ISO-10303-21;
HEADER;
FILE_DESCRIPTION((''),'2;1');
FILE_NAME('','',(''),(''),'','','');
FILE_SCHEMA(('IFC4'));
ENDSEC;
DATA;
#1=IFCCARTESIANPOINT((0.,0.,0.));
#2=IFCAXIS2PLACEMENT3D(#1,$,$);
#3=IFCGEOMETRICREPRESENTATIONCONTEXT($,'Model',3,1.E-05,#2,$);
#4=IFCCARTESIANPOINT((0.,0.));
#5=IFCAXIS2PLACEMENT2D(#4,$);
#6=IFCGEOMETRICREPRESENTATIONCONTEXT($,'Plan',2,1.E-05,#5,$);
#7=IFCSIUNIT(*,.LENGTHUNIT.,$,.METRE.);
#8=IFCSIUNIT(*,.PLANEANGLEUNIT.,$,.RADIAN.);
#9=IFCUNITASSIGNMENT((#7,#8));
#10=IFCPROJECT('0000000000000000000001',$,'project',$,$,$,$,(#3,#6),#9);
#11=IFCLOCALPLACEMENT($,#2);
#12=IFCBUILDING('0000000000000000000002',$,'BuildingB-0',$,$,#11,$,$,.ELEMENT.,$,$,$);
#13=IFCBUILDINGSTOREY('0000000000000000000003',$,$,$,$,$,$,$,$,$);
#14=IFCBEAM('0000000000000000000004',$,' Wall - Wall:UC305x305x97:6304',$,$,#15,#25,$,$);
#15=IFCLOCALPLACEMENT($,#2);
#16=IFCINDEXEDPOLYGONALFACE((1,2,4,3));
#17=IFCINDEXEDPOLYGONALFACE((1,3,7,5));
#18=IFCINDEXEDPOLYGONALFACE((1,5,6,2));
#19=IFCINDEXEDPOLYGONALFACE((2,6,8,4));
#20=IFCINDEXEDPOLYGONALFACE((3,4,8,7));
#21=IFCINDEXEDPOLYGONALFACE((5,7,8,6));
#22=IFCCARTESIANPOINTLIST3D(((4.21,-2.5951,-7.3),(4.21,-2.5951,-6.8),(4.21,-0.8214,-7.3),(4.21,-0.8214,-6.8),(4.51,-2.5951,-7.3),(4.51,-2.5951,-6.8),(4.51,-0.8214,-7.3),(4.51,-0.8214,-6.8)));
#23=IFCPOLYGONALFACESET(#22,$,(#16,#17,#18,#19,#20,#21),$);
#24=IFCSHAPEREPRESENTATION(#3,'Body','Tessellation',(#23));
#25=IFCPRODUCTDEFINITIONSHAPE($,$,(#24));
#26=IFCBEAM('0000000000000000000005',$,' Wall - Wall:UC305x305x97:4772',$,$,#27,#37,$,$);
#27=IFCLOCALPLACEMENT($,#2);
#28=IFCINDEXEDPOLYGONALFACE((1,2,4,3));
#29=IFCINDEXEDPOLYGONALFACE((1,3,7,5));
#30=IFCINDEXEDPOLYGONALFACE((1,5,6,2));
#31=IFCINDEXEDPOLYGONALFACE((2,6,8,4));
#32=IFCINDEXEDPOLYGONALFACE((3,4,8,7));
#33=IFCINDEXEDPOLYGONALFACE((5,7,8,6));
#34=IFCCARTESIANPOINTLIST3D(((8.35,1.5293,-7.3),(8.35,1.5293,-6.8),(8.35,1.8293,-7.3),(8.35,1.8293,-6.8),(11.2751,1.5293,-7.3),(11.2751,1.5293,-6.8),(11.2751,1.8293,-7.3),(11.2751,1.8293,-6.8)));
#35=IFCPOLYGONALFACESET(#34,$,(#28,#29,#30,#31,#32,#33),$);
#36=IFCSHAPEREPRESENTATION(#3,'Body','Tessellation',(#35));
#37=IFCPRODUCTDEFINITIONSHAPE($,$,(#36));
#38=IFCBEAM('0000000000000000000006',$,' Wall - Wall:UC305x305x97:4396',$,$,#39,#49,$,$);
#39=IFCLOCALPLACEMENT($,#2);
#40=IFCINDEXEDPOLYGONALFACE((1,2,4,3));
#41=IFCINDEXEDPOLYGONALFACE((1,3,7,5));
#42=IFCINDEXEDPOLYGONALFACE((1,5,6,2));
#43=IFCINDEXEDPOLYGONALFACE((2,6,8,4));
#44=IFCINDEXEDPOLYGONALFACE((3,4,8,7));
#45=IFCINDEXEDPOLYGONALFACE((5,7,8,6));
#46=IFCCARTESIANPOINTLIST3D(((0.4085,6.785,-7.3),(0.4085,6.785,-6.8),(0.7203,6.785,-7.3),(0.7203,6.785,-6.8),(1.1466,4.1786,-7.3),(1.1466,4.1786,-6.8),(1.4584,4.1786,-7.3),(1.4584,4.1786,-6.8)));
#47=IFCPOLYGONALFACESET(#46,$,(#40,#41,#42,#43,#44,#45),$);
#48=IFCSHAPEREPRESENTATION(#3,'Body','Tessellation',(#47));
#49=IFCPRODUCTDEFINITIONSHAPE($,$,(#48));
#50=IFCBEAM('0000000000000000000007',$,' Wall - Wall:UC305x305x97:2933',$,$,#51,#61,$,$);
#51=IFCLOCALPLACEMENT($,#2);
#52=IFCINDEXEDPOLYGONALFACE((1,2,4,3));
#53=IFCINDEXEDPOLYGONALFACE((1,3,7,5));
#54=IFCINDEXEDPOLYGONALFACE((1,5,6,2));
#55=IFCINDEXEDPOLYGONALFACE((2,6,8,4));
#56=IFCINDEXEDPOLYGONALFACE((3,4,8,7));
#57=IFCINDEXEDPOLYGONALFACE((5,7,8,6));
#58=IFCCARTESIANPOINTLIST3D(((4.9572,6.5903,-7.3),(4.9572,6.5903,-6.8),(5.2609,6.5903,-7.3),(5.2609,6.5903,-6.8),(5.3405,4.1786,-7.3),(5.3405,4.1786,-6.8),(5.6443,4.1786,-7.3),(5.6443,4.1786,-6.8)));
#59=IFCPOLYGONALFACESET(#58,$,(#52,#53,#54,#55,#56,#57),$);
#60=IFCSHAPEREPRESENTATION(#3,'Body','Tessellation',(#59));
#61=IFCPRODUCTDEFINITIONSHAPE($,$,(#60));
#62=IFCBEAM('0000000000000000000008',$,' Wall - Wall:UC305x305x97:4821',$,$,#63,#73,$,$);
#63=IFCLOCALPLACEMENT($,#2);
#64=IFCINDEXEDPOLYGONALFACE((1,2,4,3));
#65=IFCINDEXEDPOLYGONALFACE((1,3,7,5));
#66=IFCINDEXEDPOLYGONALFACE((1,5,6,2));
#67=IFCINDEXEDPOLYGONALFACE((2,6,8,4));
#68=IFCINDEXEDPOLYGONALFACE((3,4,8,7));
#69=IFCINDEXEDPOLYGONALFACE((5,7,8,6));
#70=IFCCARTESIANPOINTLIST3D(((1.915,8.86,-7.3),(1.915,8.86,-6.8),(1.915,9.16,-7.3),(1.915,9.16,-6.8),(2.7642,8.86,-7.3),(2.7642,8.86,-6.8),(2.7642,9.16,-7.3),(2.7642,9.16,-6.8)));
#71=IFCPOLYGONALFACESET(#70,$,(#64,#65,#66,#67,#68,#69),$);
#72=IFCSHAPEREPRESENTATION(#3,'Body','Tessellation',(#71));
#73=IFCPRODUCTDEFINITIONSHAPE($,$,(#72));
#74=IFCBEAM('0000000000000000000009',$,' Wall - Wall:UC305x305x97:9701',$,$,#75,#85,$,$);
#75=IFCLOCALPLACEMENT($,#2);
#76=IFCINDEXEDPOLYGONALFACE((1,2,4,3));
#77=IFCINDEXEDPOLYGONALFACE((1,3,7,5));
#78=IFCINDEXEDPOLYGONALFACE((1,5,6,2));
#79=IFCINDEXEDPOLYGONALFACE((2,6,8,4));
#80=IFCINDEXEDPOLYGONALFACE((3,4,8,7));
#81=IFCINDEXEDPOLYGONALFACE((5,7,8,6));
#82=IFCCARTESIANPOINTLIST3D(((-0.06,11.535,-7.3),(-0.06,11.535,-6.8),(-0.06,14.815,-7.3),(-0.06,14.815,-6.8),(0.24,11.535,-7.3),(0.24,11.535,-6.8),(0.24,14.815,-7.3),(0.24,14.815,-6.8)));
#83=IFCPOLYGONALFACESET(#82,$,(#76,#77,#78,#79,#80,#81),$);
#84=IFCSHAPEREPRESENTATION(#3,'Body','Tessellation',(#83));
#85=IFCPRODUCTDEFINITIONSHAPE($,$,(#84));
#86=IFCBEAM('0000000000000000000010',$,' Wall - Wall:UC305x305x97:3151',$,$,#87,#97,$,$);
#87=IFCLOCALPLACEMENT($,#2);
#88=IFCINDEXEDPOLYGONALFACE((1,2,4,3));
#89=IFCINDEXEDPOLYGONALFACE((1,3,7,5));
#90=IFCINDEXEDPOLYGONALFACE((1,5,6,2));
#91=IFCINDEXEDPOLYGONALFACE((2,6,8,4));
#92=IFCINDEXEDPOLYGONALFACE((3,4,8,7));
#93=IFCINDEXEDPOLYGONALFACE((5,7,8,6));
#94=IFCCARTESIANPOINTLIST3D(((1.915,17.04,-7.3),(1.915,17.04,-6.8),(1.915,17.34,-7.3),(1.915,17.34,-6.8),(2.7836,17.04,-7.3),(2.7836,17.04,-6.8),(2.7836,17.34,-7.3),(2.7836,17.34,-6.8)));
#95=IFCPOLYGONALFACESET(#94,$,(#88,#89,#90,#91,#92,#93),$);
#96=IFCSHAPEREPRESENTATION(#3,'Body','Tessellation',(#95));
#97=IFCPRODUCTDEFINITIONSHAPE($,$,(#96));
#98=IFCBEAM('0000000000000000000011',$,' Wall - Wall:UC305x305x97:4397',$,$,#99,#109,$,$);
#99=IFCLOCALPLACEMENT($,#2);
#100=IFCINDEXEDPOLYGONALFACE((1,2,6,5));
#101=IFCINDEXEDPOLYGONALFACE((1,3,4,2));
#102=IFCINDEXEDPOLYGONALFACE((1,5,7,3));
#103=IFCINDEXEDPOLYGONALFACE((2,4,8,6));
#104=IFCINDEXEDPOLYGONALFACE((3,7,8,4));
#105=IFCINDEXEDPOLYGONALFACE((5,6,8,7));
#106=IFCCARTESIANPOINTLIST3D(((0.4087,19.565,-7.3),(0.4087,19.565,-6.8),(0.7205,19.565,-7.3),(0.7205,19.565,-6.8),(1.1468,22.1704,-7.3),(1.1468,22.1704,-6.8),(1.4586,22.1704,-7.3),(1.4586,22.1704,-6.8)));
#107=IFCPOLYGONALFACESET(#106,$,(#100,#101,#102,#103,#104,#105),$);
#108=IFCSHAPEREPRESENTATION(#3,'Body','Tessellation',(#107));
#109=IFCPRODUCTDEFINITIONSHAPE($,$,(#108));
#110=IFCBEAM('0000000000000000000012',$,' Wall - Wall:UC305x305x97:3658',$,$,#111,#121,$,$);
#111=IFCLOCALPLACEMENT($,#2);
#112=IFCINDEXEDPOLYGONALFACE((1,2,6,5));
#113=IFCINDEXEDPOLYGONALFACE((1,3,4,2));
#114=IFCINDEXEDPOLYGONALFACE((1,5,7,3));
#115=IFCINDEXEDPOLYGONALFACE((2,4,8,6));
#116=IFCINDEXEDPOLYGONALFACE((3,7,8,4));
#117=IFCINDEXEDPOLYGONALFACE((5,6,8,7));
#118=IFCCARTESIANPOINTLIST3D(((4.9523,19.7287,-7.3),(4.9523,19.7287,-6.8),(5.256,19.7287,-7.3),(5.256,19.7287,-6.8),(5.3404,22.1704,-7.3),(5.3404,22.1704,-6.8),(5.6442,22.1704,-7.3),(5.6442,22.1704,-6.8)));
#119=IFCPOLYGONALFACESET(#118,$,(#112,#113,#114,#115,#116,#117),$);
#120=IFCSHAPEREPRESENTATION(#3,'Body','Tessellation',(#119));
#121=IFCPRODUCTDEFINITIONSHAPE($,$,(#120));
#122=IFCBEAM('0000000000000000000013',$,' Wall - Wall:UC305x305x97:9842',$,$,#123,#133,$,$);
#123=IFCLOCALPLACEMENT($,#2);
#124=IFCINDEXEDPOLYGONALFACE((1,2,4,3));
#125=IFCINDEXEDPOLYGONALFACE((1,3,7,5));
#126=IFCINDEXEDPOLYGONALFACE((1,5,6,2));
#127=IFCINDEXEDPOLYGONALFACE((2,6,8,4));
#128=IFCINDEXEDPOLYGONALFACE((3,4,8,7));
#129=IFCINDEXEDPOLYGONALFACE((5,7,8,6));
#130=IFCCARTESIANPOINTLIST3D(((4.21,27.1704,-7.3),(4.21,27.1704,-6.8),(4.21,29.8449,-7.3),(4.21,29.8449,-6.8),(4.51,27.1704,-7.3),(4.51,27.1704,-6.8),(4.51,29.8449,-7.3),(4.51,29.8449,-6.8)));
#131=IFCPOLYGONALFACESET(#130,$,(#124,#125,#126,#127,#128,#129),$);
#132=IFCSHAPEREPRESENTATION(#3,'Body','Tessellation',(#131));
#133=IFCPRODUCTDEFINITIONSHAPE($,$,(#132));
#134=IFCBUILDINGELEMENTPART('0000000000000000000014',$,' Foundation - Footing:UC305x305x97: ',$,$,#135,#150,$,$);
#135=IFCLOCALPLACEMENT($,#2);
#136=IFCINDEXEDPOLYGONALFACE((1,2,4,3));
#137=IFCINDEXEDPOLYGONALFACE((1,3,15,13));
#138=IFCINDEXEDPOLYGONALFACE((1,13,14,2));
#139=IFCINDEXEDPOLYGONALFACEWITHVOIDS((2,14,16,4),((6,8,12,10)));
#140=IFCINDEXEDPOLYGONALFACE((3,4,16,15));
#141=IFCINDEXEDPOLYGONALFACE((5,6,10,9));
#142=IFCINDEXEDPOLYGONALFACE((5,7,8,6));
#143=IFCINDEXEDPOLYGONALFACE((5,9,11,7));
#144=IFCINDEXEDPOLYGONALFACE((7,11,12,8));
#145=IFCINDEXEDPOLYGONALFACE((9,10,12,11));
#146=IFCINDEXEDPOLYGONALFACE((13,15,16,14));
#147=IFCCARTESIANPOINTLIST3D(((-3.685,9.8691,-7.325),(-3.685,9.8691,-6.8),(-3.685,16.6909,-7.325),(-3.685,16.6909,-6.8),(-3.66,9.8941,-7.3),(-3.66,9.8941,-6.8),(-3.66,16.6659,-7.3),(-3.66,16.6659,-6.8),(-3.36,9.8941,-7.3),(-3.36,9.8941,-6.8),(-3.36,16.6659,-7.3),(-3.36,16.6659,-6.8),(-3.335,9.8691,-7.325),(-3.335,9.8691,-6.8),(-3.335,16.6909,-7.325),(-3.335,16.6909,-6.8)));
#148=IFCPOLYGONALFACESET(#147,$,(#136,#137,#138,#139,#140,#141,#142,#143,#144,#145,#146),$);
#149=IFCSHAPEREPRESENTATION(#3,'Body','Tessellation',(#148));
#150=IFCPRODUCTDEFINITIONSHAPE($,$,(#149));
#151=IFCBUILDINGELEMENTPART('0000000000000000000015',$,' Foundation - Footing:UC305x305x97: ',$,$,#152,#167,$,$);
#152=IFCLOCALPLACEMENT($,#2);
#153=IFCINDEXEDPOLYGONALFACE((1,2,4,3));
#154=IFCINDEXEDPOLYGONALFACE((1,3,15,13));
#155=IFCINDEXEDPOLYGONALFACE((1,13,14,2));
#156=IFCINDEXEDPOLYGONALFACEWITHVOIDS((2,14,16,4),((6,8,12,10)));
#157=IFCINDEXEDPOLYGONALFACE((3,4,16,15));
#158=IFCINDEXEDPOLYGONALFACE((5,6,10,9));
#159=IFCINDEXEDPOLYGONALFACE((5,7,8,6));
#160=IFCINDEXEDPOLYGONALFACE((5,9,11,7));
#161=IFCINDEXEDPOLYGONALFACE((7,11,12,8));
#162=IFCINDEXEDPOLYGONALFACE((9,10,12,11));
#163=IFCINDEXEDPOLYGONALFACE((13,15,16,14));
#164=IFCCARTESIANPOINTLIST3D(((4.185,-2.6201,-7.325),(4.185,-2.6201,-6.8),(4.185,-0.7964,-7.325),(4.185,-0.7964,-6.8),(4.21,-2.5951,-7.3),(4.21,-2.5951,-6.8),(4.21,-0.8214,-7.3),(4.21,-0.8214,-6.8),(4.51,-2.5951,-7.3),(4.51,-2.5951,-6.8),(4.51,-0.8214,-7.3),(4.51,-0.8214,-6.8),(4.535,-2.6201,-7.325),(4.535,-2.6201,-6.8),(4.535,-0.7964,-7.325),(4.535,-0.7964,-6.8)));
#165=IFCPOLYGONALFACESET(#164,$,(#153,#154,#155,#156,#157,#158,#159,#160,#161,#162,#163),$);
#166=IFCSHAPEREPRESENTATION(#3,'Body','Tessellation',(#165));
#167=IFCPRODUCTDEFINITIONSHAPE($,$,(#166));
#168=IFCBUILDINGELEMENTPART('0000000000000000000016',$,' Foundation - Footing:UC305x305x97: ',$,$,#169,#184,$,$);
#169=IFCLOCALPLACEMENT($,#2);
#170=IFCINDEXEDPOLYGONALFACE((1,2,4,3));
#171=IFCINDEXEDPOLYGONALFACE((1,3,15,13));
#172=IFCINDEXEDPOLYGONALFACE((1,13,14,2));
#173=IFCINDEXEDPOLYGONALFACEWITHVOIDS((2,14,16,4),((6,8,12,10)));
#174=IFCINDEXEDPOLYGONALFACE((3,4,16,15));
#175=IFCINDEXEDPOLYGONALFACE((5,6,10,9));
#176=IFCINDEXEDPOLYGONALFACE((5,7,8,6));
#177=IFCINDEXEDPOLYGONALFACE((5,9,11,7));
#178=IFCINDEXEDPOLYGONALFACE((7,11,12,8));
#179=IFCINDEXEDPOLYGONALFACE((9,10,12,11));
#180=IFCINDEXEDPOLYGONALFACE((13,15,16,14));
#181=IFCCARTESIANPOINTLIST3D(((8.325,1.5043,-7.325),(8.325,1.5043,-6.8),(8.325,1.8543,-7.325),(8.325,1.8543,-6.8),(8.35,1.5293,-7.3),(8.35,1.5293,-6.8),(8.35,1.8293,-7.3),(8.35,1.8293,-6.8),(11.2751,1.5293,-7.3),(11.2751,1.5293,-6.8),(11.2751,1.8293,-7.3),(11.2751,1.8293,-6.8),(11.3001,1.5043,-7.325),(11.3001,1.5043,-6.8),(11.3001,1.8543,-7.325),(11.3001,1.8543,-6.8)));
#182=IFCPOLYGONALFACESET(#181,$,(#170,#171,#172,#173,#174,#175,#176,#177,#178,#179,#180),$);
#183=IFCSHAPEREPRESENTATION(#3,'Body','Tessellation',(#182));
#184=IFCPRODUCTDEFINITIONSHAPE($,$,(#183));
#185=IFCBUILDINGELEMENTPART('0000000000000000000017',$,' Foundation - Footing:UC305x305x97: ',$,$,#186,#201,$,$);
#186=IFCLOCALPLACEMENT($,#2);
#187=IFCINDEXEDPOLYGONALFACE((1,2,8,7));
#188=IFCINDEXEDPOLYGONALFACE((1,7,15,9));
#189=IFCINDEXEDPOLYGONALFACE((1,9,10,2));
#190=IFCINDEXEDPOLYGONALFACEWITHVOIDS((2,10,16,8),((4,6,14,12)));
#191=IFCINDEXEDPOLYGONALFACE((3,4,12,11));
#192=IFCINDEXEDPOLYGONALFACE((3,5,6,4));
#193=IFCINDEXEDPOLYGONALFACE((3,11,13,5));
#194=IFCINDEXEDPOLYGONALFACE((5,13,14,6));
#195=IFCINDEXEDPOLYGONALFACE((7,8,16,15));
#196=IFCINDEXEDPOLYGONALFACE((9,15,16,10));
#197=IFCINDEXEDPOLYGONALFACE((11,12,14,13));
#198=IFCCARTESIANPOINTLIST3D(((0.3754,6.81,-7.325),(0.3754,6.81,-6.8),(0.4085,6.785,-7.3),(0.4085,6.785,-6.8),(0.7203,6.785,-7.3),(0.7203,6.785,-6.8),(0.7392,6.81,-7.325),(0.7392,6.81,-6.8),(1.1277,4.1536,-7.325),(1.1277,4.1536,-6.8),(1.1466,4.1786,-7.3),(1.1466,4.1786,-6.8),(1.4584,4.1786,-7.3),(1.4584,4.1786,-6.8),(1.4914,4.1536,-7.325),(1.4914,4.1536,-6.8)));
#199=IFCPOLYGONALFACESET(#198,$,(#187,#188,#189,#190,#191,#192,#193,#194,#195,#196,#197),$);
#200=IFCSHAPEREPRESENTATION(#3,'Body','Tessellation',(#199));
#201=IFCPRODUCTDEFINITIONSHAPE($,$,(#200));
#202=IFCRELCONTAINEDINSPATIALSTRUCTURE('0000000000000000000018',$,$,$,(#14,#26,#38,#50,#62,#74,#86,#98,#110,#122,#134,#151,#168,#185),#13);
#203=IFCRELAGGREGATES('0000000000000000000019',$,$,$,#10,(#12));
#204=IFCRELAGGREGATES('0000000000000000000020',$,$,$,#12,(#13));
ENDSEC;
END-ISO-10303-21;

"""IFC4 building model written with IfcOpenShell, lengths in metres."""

from ifc_helpers import new_model, si_unit, origin, origin_2d, place, context, project, spatial, polyline, outline, extrude, element, save


model = new_model("IFC4")

# Units and contexts
model_context = context("Model", 3, precision=1e-05, world=origin())
plan_context = context("Plan", 2, precision=1e-05, world=origin_2d())
ifc_project = project(units=[si_unit("LENGTHUNIT", "METRE"), si_unit("PLANEANGLEUNIT", "RADIAN")], contexts=[model_context, plan_context])

# Building, storey
building_placement = place(None, origin())
building = spatial("IfcBuilding", under=ifc_project, at=building_placement, Name="BuildingB-0", CompositionType="ELEMENT")
storey = spatial("IfcBuildingStorey", under=building)

# Beams
element("IfcBeam", 1, inside=storey, Name=" Wall - Wall:UC305x305x97:6304", context=model_context, shape_type="SweptSolid", body=[
    extrude(outline(polyline([(4.21, -2.5951, -7.3), (4.51, -2.5951, -7.3), (4.51, -0.8214, -7.3), (4.21, -0.8214, -7.3), (4.21, -2.5951, -7.3)])), None, (0.0, 0.0, 1.0), 0.5),
])
element("IfcBeam", 2, inside=storey, Name=" Wall - Wall:UC305x305x97:4772", context=model_context, shape_type="SweptSolid", body=[
    extrude(outline(polyline([(8.35, 1.5293, -7.3), (8.35, 1.8293, -7.3), (11.2751, 1.8293, -7.3), (11.2751, 1.5293, -7.3), (8.35, 1.5293, -7.3)])), None, (0.0, 0.0, 1.0), 0.5),
])
element("IfcBeam", 3, inside=storey, Name=" Wall - Wall:UC305x305x97:4396", context=model_context, shape_type="SweptSolid", body=[
    extrude(outline(polyline([(1.1466, 4.1786, -7.3), (0.4085, 6.785, -7.3), (0.7203, 6.785, -7.3), (1.4584, 4.1786, -7.3), (1.1466, 4.1786, -7.3)])), None, (0.0, 0.0, 1.0), 0.5),
])
element("IfcBeam", 4, inside=storey, Name=" Wall - Wall:UC305x305x97:2933", context=model_context, shape_type="SweptSolid", body=[
    extrude(outline(polyline([(5.3405, 4.1786, -7.3), (4.9572, 6.5903, -7.3), (5.2609, 6.5903, -7.3), (5.6443, 4.1786, -7.3), (5.3405, 4.1786, -7.3)])), None, (0.0, 0.0, 1.0), 0.5),
])
element("IfcBeam", 5, inside=storey, Name=" Wall - Wall:UC305x305x97:4821", context=model_context, shape_type="SweptSolid", body=[
    extrude(outline(polyline([(1.915, 8.86, -7.3), (1.915, 9.16, -7.3), (2.7642, 9.16, -7.3), (2.7642, 8.86, -7.3), (1.915, 8.86, -7.3)])), None, (0.0, 0.0, 1.0), 0.5),
])
element("IfcBeam", 6, inside=storey, Name=" Wall - Wall:UC305x305x97:9701", context=model_context, shape_type="SweptSolid", body=[
    extrude(outline(polyline([(-0.06, 11.535, -7.3), (-0.06, 14.815, -7.3), (0.24, 14.815, -7.3), (0.24, 11.535, -7.3), (-0.06, 11.535, -7.3)])), None, (0.0, 0.0, 1.0), 0.5),
])
element("IfcBeam", 7, inside=storey, Name=" Wall - Wall:UC305x305x97:3151", context=model_context, shape_type="SweptSolid", body=[
    extrude(outline(polyline([(1.915, 17.04, -7.3), (1.915, 17.34, -7.3), (2.7836, 17.34, -7.3), (2.7836, 17.04, -7.3), (1.915, 17.04, -7.3)])), None, (0.0, 0.0, 1.0), 0.5),
])
element("IfcBeam", 8, inside=storey, Name=" Wall - Wall:UC305x305x97:4397", context=model_context, shape_type="SweptSolid", body=[
    extrude(outline(polyline([(0.4087, 19.565, -7.3), (1.1468, 22.1704, -7.3), (1.4586, 22.1704, -7.3), (0.7205, 19.565, -7.3), (0.4087, 19.565, -7.3)])), None, (0.0, 0.0, 1.0), 0.5),
])
element("IfcBeam", 9, inside=storey, Name=" Wall - Wall:UC305x305x97:3658", context=model_context, shape_type="SweptSolid", body=[
    extrude(outline(polyline([(5.256, 19.7287, -7.3), (4.9523, 19.7287, -7.3), (5.3404, 22.1704, -7.3), (5.6442, 22.1704, -7.3), (5.256, 19.7287, -7.3)])), None, (0.0, 0.0, 1.0), 0.5),
])
element("IfcBeam", 10, inside=storey, Name=" Wall - Wall:UC305x305x97:9842", context=model_context, shape_type="SweptSolid", body=[
    extrude(outline(polyline([(4.51, 27.1704, -7.3), (4.21, 27.1704, -7.3), (4.21, 29.8449, -7.3), (4.51, 29.8449, -7.3), (4.51, 27.1704, -7.3)])), None, (0.0, 0.0, 1.0), 0.5),
])

# Building element parts, openings
building_element_part_1 = element("IfcBuildingElementPart", 11, inside=storey, Name=" Foundation - Footing:UC305x305x97: ", context=model_context, shape_type="SweptSolid", body=[
    extrude(outline(polyline([(-3.685, 9.8691, -7.325), (-3.335, 9.8691, -7.325), (-3.335, 16.6909, -7.325), (-3.685, 16.6909, -7.325), (-3.685, 9.8691, -7.325)])), None, (0.0, 0.0, 1.0), 0.525),
])
element("IfcOpeningElement", 12, inside=storey, cuts=building_element_part_1, context=model_context, shape_type="SweptSolid", body=[
    extrude(outline(polyline([(-3.66, 9.8941, -7.3), (-3.36, 9.8941, -7.3), (-3.36, 16.6659, -7.3), (-3.66, 16.6659, -7.3), (-3.66, 9.8941, -7.3)])), None, (0.0, 0.0, 1.0), 0.5),
])
building_element_part_2 = element("IfcBuildingElementPart", 13, inside=storey, Name=" Foundation - Footing:UC305x305x97: ", context=model_context, shape_type="SweptSolid", body=[
    extrude(outline(polyline([(4.185, -2.6201, -7.325), (4.535, -2.6201, -7.325), (4.535, -0.7964, -7.325), (4.185, -0.7964, -7.325), (4.185, -2.6201, -7.325)])), None, (0.0, 0.0, 1.0), 0.525),
])
element("IfcOpeningElement", 14, inside=storey, cuts=building_element_part_2, context=model_context, shape_type="SweptSolid", body=[
    extrude(outline(polyline([(4.21, -2.5951, -7.3), (4.51, -2.5951, -7.3), (4.51, -0.8214, -7.3), (4.21, -0.8214, -7.3), (4.21, -2.5951, -7.3)])), None, (0.0, 0.0, 1.0), 0.5),
])
building_element_part_3 = element("IfcBuildingElementPart", 15, inside=storey, Name=" Foundation - Footing:UC305x305x97: ", context=model_context, shape_type="SweptSolid", body=[
    extrude(outline(polyline([(8.325, 1.5043, -7.325), (8.325, 1.8543, -7.325), (11.3001, 1.8543, -7.325), (11.3001, 1.5043, -7.325), (8.325, 1.5043, -7.325)])), None, (0.0, 0.0, 1.0), 0.525),
])
element("IfcOpeningElement", 16, inside=storey, cuts=building_element_part_3, context=model_context, shape_type="SweptSolid", body=[
    extrude(outline(polyline([(8.35, 1.5293, -7.3), (8.35, 1.8293, -7.3), (11.2751, 1.8293, -7.3), (11.2751, 1.5293, -7.3), (8.35, 1.5293, -7.3)])), None, (0.0, 0.0, 1.0), 0.5),
])
building_element_part_4 = element("IfcBuildingElementPart", 17, inside=storey, Name=" Foundation - Footing:UC305x305x97: ", context=model_context, shape_type="SweptSolid", body=[
    extrude(outline(polyline([(1.1277, 4.1536, -7.325), (0.3754, 6.81, -7.325), (0.7392, 6.81, -7.325), (1.4914, 4.1536, -7.325), (1.1277, 4.1536, -7.325)])), None, (0.0, 0.0, 1.0), 0.525),
])
element("IfcOpeningElement", 18, inside=storey, cuts=building_element_part_4, context=model_context, shape_type="SweptSolid", body=[
    extrude(outline(polyline([(1.1466, 4.1786, -7.3), (0.4085, 6.785, -7.3), (0.7203, 6.785, -7.3), (1.4584, 4.1786, -7.3), (1.1466, 4.1786, -7.3)])), None, (0.0, 0.0, 1.0), 0.5),
])

save(model, "model.ifc")
